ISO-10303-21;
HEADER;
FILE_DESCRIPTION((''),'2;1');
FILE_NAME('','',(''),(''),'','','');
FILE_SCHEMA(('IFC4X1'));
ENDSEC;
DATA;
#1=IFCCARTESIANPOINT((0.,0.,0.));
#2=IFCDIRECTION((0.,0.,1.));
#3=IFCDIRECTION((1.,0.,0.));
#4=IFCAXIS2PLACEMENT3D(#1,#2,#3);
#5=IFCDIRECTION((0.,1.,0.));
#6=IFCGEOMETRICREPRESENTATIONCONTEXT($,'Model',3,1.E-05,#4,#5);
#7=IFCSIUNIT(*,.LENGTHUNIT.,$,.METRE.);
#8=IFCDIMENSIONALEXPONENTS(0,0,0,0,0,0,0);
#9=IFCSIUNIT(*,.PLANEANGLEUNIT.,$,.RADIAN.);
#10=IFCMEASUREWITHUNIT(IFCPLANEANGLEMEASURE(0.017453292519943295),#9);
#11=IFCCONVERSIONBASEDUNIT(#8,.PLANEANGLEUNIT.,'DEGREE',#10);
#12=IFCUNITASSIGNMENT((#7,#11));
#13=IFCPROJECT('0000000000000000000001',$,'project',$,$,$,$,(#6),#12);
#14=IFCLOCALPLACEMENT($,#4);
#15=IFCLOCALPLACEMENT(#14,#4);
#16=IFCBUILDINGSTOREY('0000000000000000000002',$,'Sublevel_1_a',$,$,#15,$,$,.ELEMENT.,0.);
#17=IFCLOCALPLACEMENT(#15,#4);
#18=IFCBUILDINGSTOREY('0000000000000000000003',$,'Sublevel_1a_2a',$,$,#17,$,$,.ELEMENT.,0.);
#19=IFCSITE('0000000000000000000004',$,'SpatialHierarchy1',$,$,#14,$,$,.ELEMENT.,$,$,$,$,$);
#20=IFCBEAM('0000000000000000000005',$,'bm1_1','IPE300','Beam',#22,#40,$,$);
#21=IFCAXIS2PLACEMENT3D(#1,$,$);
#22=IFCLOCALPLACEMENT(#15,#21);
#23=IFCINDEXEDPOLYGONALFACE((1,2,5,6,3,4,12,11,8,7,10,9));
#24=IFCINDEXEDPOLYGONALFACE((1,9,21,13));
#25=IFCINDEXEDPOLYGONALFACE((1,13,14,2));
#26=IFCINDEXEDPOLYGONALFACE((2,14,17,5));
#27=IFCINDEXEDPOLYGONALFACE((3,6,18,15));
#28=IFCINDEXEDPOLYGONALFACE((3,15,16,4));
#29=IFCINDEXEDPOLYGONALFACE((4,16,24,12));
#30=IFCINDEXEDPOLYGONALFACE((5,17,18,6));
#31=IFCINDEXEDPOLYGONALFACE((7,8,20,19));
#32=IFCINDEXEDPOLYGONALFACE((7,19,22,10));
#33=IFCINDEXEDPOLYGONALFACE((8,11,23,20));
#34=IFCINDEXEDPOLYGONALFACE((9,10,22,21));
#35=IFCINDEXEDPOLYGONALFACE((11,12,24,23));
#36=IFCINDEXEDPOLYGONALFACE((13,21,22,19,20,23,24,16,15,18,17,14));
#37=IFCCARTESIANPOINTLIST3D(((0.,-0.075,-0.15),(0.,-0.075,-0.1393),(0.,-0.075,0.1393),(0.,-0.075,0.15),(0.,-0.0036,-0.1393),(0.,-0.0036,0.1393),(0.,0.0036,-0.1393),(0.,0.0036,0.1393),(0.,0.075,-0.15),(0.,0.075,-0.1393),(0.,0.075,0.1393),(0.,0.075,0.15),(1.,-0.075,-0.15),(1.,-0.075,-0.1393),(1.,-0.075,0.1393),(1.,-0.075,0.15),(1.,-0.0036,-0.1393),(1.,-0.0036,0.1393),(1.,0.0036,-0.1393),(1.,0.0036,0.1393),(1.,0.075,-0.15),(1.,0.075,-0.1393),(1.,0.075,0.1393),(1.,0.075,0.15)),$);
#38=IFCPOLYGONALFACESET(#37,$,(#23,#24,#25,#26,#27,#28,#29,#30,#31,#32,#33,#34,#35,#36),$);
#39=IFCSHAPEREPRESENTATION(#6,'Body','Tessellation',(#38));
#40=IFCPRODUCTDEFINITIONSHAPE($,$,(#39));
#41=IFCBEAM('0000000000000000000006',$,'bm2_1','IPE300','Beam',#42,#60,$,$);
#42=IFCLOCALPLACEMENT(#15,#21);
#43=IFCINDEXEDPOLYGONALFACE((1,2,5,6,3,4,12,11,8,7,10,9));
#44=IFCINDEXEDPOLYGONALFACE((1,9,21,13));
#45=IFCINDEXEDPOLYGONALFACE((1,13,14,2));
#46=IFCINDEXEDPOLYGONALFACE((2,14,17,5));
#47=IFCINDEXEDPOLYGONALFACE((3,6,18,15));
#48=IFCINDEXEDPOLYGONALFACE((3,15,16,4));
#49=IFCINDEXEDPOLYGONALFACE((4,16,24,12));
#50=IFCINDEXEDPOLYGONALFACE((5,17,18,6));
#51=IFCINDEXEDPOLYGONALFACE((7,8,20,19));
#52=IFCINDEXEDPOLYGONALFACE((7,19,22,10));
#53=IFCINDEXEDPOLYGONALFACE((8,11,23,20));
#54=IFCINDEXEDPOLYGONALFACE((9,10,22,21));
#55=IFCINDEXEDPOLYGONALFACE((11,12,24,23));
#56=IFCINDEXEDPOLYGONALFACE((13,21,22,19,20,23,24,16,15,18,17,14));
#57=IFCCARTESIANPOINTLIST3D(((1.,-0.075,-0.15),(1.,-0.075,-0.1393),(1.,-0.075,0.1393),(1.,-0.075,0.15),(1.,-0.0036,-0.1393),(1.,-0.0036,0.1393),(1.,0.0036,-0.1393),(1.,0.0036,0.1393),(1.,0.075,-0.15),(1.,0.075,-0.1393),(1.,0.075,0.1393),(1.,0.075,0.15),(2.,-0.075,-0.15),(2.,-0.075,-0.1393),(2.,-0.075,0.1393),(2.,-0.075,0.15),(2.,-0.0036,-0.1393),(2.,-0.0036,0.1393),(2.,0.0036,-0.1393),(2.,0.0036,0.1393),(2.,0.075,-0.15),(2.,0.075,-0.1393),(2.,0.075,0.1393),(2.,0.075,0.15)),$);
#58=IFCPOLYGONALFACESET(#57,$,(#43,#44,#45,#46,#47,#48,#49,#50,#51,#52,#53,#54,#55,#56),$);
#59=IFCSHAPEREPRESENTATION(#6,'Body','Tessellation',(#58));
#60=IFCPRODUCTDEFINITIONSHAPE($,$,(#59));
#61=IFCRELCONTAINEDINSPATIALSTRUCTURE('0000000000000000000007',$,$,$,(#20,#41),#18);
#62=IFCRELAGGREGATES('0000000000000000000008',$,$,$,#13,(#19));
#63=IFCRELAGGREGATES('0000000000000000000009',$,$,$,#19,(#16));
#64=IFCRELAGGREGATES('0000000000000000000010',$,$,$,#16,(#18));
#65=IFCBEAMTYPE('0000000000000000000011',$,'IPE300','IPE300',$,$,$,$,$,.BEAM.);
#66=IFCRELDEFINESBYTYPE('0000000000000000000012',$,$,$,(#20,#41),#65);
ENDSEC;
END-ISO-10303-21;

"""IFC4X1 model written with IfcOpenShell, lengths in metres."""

from ifc_helpers import new_model, entity, si_unit, converted_unit, direction, frame, origin, origin_with_axes, place, context, project, spatial, i_section, extrude, type_object, element, save


model = new_model("IFC4X1")

# Units and contexts
model_context = context("Model", 3, precision=1e-05, world=origin_with_axes(), true_north=direction((0.0, 1.0, 0.0)))
ifc_project = project(units=[si_unit("LENGTHUNIT", "METRE"), converted_unit("PLANEANGLEUNIT", "DEGREE", entity("IfcPlaneAngleMeasure", 0.017453292519943295), si_unit("PLANEANGLEUNIT", "RADIAN"), dimensions=[0, 0, 0, 0, 0, 0, 0])], contexts=[model_context])

# Site, storeys
site_placement = place(None, origin_with_axes())
site = spatial("IfcSite", under=ifc_project, at=site_placement, Name="SpatialHierarchy1", CompositionType="ELEMENT")
storey_1_placement = place(site_placement, origin_with_axes())
storey_1 = spatial("IfcBuildingStorey", under=site, at=storey_1_placement, Name="Sublevel_1_a", CompositionType="ELEMENT", Elevation=0.0)
storey_2_placement = place(storey_1_placement, origin_with_axes())
storey_2 = spatial("IfcBuildingStorey", under=storey_1, at=storey_2_placement, Name="Sublevel_1a_2a", CompositionType="ELEMENT", Elevation=0.0)

# Beams
beam_type = type_object("IfcBeamType", Name="IPE300", Description="IPE300", PredefinedType="BEAM")
placement_1 = place(storey_2_placement, origin_with_axes())
beam_1_placement = place(placement_1, frame((0.0, 0.0, 0.0), z_axis=(1.0, 0.0, 0.0), x_axis=(0.0, 1.0, 0.0)))
element("IfcBeam", 1, at=beam_1_placement, inside=storey_2, type_object=beam_type, Name="bm1_1", Description="IPE300", ObjectType="Beam", context=model_context, shape_type="SweptSolid", body=[
    extrude(i_section(OverallWidth=0.15, OverallDepth=0.3, WebThickness=0.0071, FlangeThickness=0.0107), origin(), (0.0, 0.0, 1.0), 1.0),
])
placement_2 = place(storey_2_placement, origin_with_axes())
beam_2_placement = place(placement_2, frame((1.0, 0.0, 0.0), z_axis=(1.0, 0.0, 0.0), x_axis=(0.0, 1.0, 0.0)))
element("IfcBeam", 2, at=beam_2_placement, inside=storey_2, type_object=beam_type, Name="bm2_1", Description="IPE300", ObjectType="Beam", context=model_context, shape_type="SweptSolid", body=[
    extrude(i_section(OverallWidth=0.15, OverallDepth=0.3, WebThickness=0.0071, FlangeThickness=0.0107), origin(), (0.0, 0.0, 1.0), 1.0),
])

save(model, "model.ifc")
